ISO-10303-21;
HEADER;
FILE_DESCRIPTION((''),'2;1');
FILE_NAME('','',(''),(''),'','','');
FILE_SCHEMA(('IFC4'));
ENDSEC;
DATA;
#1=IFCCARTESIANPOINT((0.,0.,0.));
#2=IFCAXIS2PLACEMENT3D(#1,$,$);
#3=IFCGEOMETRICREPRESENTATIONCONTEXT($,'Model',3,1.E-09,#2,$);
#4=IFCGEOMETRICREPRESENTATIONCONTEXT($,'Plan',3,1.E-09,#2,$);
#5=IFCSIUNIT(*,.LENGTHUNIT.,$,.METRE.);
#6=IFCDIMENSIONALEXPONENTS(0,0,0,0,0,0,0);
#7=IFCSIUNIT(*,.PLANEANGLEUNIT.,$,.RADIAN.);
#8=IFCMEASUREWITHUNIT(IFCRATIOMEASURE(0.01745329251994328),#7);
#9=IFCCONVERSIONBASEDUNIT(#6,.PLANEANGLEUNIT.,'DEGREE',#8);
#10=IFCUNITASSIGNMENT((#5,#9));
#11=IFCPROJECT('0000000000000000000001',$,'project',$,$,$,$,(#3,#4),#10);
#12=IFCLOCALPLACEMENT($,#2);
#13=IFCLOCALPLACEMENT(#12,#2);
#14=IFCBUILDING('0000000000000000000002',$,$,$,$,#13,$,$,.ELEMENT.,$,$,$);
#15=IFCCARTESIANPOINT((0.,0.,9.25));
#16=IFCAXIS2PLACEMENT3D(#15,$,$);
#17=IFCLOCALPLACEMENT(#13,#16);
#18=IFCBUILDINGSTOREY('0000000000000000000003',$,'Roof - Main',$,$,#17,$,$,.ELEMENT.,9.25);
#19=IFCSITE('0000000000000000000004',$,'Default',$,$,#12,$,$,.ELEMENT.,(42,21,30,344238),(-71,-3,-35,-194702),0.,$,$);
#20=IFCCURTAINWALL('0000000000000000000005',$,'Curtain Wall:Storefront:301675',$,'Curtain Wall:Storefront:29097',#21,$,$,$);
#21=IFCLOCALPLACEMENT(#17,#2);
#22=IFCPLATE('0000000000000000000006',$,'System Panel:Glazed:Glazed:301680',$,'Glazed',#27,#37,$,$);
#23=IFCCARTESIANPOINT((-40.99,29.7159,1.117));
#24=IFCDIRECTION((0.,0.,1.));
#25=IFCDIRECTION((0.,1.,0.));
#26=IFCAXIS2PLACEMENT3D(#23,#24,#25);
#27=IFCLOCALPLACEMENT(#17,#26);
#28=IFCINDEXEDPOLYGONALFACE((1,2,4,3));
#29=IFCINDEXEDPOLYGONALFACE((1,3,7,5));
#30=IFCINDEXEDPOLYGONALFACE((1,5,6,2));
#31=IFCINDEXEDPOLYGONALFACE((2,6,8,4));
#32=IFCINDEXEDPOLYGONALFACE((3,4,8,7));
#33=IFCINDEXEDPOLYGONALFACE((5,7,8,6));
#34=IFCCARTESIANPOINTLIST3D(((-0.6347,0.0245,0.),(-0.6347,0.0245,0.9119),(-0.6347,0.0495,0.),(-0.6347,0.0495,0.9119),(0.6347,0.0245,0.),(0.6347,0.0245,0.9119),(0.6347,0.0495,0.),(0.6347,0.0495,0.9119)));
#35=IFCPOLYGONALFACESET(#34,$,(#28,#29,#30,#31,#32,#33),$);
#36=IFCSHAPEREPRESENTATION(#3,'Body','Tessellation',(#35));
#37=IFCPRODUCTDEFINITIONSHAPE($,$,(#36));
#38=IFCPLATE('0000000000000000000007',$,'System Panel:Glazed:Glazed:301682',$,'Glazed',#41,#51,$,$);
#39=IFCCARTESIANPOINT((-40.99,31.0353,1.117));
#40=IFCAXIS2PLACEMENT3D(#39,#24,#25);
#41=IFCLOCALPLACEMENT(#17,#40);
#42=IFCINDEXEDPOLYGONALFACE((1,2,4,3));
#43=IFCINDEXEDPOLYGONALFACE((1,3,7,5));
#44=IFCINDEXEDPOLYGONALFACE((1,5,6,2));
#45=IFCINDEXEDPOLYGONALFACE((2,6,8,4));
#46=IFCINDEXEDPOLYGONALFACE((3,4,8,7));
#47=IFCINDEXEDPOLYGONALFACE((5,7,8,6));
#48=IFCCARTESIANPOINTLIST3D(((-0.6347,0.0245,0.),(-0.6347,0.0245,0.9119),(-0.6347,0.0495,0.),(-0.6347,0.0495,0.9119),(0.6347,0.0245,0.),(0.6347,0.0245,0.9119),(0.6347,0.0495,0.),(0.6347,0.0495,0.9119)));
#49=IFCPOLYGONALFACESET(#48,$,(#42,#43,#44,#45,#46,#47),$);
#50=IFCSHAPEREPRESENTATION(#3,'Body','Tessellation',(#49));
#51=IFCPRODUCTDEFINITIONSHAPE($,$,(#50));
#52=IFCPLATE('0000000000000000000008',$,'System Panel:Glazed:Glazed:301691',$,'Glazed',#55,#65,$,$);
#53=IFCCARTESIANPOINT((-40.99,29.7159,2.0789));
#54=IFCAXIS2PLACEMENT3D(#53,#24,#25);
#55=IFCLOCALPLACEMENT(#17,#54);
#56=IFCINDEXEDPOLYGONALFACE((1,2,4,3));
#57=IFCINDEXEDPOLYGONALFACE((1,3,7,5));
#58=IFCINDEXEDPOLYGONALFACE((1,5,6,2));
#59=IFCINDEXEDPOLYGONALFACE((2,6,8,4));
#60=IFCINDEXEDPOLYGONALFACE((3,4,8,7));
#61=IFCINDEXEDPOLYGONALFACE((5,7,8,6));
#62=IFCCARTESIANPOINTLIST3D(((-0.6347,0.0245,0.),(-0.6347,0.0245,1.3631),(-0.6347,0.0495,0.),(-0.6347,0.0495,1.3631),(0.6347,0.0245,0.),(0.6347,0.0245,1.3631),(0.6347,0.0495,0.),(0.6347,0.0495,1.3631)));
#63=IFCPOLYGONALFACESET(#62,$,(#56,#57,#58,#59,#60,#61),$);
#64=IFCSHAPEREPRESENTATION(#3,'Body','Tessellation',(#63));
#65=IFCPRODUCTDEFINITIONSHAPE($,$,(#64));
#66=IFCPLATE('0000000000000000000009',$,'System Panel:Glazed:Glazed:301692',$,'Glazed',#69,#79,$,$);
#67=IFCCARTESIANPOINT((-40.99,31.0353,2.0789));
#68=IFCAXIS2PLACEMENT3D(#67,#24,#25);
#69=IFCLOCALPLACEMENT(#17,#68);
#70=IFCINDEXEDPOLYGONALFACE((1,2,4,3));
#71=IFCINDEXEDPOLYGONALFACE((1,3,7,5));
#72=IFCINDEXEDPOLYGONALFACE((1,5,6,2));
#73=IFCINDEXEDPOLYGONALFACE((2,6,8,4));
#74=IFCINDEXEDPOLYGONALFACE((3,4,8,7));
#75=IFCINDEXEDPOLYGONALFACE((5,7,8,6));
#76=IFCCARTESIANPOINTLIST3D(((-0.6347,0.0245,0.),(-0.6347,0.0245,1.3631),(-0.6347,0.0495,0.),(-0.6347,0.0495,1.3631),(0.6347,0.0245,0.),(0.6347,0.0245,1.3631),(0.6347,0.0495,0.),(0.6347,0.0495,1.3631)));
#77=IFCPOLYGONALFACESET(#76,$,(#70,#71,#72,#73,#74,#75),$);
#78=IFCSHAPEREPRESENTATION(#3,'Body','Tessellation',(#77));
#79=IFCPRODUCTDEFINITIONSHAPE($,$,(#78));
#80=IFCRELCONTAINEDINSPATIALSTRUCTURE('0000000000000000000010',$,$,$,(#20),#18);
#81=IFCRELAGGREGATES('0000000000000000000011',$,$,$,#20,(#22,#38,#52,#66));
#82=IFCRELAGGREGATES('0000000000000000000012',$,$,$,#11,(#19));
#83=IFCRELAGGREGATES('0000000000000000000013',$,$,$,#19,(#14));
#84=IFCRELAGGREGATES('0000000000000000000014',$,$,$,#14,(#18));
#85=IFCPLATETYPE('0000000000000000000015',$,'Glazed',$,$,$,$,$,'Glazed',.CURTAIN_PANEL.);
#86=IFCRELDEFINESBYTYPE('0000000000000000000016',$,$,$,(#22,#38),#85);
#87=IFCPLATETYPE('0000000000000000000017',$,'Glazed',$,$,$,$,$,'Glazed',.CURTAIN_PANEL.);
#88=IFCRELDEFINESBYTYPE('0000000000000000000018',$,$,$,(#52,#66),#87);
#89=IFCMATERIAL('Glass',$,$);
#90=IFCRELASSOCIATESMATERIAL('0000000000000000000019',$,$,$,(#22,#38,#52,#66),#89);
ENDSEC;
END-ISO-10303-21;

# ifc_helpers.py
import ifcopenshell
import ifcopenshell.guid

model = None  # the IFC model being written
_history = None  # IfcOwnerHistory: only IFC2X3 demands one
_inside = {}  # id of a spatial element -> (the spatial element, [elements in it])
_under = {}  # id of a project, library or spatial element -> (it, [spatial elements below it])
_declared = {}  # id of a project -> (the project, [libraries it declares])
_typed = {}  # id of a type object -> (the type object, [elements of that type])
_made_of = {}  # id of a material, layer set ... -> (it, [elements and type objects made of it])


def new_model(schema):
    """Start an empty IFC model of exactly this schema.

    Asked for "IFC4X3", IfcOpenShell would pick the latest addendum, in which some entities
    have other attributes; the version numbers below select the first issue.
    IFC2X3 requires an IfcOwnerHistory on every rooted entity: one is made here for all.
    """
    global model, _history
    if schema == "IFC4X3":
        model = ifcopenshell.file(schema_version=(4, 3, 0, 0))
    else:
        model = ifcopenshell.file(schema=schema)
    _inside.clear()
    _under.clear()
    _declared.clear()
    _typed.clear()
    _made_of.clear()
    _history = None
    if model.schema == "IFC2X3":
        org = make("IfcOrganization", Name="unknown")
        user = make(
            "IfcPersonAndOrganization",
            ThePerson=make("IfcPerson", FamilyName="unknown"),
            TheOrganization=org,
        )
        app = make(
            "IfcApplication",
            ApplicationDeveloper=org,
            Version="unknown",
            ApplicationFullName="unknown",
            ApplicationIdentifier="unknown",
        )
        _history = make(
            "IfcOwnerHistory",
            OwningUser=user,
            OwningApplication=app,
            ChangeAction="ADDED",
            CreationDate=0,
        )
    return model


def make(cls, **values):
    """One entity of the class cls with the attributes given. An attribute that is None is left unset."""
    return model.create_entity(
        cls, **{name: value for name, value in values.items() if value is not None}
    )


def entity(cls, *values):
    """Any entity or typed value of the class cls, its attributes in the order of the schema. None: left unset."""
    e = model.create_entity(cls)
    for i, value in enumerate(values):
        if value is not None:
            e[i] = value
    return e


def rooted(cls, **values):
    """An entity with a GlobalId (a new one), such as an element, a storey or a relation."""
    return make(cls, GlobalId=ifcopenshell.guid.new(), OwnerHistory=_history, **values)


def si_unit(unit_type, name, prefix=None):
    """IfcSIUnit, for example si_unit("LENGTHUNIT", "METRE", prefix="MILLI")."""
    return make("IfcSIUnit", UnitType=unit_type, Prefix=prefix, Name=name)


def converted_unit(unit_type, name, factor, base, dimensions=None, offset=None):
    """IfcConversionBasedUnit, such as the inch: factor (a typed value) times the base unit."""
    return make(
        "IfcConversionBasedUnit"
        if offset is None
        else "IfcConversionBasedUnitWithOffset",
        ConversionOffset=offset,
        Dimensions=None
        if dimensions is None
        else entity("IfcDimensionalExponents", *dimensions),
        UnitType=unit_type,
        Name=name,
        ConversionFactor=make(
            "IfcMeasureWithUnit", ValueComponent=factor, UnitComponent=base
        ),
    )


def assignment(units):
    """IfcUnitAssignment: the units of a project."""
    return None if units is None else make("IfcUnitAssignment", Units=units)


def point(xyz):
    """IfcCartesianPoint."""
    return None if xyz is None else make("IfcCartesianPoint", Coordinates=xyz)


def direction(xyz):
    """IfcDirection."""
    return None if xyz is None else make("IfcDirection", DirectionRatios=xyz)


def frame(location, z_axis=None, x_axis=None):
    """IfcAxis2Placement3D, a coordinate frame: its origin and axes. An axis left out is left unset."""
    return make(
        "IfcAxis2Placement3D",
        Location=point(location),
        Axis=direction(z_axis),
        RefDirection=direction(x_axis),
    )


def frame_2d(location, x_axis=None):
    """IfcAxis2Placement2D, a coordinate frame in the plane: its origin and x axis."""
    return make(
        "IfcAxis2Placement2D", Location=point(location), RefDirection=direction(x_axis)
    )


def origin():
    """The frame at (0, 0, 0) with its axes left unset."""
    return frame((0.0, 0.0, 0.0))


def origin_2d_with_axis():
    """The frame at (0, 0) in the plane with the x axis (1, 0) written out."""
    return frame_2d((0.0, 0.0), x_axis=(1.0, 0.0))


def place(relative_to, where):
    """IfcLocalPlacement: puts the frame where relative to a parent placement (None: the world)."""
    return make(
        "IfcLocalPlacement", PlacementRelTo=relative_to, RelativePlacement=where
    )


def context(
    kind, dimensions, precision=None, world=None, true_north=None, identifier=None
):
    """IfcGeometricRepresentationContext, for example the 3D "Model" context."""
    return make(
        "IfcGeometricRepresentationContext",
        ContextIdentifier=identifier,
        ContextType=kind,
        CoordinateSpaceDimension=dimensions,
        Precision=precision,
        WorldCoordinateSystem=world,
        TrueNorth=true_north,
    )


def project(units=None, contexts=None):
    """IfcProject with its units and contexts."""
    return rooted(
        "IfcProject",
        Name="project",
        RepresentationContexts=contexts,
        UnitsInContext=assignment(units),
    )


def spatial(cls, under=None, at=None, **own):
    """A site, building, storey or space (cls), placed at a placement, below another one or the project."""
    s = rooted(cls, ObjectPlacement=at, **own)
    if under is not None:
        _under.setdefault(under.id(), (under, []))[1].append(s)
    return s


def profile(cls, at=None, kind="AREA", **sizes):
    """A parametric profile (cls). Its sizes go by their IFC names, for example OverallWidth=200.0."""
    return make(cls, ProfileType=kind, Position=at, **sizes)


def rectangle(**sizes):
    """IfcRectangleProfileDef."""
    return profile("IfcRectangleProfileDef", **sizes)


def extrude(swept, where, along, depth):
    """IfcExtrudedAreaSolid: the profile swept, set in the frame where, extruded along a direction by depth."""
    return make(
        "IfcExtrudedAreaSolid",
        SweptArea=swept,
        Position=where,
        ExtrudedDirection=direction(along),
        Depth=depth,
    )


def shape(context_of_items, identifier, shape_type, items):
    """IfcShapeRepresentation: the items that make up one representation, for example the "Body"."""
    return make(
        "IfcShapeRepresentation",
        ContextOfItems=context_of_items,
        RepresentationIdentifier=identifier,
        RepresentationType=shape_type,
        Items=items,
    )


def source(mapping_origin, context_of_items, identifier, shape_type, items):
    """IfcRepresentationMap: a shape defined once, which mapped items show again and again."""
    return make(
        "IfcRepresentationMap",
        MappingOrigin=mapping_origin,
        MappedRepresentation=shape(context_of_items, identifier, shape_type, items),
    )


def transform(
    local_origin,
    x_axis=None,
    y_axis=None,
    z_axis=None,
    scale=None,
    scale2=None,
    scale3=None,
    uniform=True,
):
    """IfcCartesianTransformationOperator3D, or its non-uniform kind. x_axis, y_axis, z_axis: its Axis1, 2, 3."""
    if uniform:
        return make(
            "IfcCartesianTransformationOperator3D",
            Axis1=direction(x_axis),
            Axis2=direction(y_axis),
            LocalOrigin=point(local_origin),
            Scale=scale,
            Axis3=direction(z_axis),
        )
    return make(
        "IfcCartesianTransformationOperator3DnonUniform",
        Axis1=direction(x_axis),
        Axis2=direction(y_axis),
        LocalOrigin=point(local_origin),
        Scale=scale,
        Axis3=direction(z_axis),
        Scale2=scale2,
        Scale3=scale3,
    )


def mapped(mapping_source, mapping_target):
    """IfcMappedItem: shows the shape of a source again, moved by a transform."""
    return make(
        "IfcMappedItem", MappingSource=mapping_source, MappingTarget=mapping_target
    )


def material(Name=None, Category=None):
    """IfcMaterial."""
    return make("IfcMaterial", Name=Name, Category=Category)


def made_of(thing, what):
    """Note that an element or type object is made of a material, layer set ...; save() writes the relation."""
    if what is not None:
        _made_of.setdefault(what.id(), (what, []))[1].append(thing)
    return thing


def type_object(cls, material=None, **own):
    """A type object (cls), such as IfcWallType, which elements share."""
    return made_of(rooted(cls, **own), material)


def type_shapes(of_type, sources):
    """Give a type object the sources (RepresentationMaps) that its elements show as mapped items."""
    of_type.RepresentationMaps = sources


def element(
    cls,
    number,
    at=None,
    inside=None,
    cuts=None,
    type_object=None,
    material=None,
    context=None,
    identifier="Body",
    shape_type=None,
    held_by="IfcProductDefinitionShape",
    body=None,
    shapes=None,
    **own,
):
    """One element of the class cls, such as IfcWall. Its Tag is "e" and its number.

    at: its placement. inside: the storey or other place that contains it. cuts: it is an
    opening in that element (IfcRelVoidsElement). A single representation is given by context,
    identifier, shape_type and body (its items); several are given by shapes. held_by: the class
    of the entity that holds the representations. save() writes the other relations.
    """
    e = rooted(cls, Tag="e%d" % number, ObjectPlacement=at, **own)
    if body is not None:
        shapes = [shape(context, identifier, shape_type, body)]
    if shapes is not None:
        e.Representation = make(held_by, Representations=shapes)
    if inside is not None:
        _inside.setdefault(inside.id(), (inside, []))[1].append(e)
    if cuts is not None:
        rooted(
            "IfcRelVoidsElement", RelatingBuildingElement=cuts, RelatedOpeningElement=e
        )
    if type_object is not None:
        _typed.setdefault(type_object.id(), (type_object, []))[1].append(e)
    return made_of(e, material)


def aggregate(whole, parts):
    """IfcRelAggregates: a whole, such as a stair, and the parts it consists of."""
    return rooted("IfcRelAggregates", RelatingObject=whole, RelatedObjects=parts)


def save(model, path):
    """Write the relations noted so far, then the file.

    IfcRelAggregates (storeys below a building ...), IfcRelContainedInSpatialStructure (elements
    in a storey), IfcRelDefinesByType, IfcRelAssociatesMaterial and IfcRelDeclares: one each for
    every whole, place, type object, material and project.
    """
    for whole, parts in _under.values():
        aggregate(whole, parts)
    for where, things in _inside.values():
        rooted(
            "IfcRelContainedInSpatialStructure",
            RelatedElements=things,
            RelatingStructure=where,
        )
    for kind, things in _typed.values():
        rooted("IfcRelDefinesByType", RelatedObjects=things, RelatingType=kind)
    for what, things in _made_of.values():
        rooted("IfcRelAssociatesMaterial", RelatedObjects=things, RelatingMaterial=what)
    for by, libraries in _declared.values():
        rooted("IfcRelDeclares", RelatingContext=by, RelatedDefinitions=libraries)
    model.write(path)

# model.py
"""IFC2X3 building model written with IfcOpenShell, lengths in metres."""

from ifc_helpers import new_model, entity, si_unit, converted_unit, frame, origin, origin_2d_with_axis, place, context, project, spatial, rectangle, extrude, source, transform, mapped, material, type_object, type_shapes, element, aggregate, save


model = new_model("IFC2X3")

# Units and contexts
model_context = context("Model", 3, precision=1e-09, world=origin())
plan_context = context("Plan", 3, precision=1e-09, world=origin())
ifc_project = project(units=[si_unit("LENGTHUNIT", "METRE"), converted_unit("PLANEANGLEUNIT", "DEGREE", entity("IfcRatioMeasure", 0.01745329251994328), si_unit("PLANEANGLEUNIT", "RADIAN"), dimensions=[0, 0, 0, 0, 0, 0, 0])], contexts=[model_context, plan_context])

# Site, building, storey
site_placement = place(None, origin())
site = spatial("IfcSite", under=ifc_project, at=site_placement, Name="Default", CompositionType="ELEMENT", RefLatitude=(42, 21, 30, 344238), RefLongitude=(-71, -3, -35, -194702), RefElevation=0.0)
building_placement = place(site_placement, origin())
building = spatial("IfcBuilding", under=site, at=building_placement, CompositionType="ELEMENT")
storey_placement = place(building_placement, frame((0.0, 0.0, 9.25)))
storey = spatial("IfcBuildingStorey", under=building, at=storey_placement, Name="Roof - Main", CompositionType="ELEMENT", Elevation=9.25)

# Curtain wall, plates
curtain_wall_placement = place(storey_placement, origin())
curtain_wall = element("IfcCurtainWall", 1, at=curtain_wall_placement, inside=storey, Name="Curtain Wall:Storefront:301675", ObjectType="Curtain Wall:Storefront:29097")
ifc_material_1 = material(Name="Glass")
plate_type_1 = type_object("IfcPlateType", Name="Glazed", ElementType="Glazed", PredefinedType="CURTAIN_PANEL")
shared_shape_1 = source(origin(), model_context, "Body", "SweptSolid", [
    extrude(rectangle(XDim=0.025, YDim=1.2694, at=origin_2d_with_axis()), frame((0.0, 0.037, 0.0), z_axis=(0.0, 0.0, 1.0), x_axis=(0.0, 1.0, 0.0)), (0.0, 0.0, 1.0), 0.9119),
])
type_shapes(plate_type_1, [shared_shape_1])
plate_1_placement = place(storey_placement, frame((-40.99, 29.7159, 1.117), z_axis=(0.0, 0.0, 1.0), x_axis=(0.0, 1.0, 0.0)))
plate_1 = element("IfcPlate", 2, at=plate_1_placement, type_object=plate_type_1, material=ifc_material_1, Name="System Panel:Glazed:Glazed:301680", ObjectType="Glazed", context=model_context, shape_type="MappedRepresentation", body=[
    mapped(shared_shape_1, transform((0.0, 0.0, 0.0), scale=1.0)),
])
plate_2_placement = place(storey_placement, frame((-40.99, 31.0353, 1.117), z_axis=(0.0, 0.0, 1.0), x_axis=(0.0, 1.0, 0.0)))
plate_2 = element("IfcPlate", 3, at=plate_2_placement, type_object=plate_type_1, material=ifc_material_1, Name="System Panel:Glazed:Glazed:301682", ObjectType="Glazed", context=model_context, shape_type="MappedRepresentation", body=[
    mapped(shared_shape_1, transform((0.0, 0.0, 0.0), scale=1.0)),
])
plate_type_2 = type_object("IfcPlateType", Name="Glazed", ElementType="Glazed", PredefinedType="CURTAIN_PANEL")
shared_shape_2 = source(origin(), model_context, "Body", "SweptSolid", [
    extrude(rectangle(XDim=0.025, YDim=1.2694, at=origin_2d_with_axis()), frame((0.0, 0.037, 0.0), z_axis=(0.0, 0.0, 1.0), x_axis=(0.0, 1.0, 0.0)), (0.0, 0.0, 1.0), 1.3631),
])
type_shapes(plate_type_2, [shared_shape_2])
plate_3_placement = place(storey_placement, frame((-40.99, 29.7159, 2.0789), z_axis=(0.0, 0.0, 1.0), x_axis=(0.0, 1.0, 0.0)))
plate_3 = element("IfcPlate", 4, at=plate_3_placement, type_object=plate_type_2, material=ifc_material_1, Name="System Panel:Glazed:Glazed:301691", ObjectType="Glazed", context=model_context, shape_type="MappedRepresentation", body=[
    mapped(shared_shape_2, transform((0.0, 0.0, 0.0), scale=1.0)),
])
plate_4_placement = place(storey_placement, frame((-40.99, 31.0353, 2.0789), z_axis=(0.0, 0.0, 1.0), x_axis=(0.0, 1.0, 0.0)))
plate_4 = element("IfcPlate", 5, at=plate_4_placement, type_object=plate_type_2, material=ifc_material_1, Name="System Panel:Glazed:Glazed:301692", ObjectType="Glazed", context=model_context, shape_type="MappedRepresentation", body=[
    mapped(shared_shape_2, transform((0.0, 0.0, 0.0), scale=1.0)),
])
aggregate(curtain_wall, [plate_1, plate_2, plate_3, plate_4])

save(model, "model.ifc")
